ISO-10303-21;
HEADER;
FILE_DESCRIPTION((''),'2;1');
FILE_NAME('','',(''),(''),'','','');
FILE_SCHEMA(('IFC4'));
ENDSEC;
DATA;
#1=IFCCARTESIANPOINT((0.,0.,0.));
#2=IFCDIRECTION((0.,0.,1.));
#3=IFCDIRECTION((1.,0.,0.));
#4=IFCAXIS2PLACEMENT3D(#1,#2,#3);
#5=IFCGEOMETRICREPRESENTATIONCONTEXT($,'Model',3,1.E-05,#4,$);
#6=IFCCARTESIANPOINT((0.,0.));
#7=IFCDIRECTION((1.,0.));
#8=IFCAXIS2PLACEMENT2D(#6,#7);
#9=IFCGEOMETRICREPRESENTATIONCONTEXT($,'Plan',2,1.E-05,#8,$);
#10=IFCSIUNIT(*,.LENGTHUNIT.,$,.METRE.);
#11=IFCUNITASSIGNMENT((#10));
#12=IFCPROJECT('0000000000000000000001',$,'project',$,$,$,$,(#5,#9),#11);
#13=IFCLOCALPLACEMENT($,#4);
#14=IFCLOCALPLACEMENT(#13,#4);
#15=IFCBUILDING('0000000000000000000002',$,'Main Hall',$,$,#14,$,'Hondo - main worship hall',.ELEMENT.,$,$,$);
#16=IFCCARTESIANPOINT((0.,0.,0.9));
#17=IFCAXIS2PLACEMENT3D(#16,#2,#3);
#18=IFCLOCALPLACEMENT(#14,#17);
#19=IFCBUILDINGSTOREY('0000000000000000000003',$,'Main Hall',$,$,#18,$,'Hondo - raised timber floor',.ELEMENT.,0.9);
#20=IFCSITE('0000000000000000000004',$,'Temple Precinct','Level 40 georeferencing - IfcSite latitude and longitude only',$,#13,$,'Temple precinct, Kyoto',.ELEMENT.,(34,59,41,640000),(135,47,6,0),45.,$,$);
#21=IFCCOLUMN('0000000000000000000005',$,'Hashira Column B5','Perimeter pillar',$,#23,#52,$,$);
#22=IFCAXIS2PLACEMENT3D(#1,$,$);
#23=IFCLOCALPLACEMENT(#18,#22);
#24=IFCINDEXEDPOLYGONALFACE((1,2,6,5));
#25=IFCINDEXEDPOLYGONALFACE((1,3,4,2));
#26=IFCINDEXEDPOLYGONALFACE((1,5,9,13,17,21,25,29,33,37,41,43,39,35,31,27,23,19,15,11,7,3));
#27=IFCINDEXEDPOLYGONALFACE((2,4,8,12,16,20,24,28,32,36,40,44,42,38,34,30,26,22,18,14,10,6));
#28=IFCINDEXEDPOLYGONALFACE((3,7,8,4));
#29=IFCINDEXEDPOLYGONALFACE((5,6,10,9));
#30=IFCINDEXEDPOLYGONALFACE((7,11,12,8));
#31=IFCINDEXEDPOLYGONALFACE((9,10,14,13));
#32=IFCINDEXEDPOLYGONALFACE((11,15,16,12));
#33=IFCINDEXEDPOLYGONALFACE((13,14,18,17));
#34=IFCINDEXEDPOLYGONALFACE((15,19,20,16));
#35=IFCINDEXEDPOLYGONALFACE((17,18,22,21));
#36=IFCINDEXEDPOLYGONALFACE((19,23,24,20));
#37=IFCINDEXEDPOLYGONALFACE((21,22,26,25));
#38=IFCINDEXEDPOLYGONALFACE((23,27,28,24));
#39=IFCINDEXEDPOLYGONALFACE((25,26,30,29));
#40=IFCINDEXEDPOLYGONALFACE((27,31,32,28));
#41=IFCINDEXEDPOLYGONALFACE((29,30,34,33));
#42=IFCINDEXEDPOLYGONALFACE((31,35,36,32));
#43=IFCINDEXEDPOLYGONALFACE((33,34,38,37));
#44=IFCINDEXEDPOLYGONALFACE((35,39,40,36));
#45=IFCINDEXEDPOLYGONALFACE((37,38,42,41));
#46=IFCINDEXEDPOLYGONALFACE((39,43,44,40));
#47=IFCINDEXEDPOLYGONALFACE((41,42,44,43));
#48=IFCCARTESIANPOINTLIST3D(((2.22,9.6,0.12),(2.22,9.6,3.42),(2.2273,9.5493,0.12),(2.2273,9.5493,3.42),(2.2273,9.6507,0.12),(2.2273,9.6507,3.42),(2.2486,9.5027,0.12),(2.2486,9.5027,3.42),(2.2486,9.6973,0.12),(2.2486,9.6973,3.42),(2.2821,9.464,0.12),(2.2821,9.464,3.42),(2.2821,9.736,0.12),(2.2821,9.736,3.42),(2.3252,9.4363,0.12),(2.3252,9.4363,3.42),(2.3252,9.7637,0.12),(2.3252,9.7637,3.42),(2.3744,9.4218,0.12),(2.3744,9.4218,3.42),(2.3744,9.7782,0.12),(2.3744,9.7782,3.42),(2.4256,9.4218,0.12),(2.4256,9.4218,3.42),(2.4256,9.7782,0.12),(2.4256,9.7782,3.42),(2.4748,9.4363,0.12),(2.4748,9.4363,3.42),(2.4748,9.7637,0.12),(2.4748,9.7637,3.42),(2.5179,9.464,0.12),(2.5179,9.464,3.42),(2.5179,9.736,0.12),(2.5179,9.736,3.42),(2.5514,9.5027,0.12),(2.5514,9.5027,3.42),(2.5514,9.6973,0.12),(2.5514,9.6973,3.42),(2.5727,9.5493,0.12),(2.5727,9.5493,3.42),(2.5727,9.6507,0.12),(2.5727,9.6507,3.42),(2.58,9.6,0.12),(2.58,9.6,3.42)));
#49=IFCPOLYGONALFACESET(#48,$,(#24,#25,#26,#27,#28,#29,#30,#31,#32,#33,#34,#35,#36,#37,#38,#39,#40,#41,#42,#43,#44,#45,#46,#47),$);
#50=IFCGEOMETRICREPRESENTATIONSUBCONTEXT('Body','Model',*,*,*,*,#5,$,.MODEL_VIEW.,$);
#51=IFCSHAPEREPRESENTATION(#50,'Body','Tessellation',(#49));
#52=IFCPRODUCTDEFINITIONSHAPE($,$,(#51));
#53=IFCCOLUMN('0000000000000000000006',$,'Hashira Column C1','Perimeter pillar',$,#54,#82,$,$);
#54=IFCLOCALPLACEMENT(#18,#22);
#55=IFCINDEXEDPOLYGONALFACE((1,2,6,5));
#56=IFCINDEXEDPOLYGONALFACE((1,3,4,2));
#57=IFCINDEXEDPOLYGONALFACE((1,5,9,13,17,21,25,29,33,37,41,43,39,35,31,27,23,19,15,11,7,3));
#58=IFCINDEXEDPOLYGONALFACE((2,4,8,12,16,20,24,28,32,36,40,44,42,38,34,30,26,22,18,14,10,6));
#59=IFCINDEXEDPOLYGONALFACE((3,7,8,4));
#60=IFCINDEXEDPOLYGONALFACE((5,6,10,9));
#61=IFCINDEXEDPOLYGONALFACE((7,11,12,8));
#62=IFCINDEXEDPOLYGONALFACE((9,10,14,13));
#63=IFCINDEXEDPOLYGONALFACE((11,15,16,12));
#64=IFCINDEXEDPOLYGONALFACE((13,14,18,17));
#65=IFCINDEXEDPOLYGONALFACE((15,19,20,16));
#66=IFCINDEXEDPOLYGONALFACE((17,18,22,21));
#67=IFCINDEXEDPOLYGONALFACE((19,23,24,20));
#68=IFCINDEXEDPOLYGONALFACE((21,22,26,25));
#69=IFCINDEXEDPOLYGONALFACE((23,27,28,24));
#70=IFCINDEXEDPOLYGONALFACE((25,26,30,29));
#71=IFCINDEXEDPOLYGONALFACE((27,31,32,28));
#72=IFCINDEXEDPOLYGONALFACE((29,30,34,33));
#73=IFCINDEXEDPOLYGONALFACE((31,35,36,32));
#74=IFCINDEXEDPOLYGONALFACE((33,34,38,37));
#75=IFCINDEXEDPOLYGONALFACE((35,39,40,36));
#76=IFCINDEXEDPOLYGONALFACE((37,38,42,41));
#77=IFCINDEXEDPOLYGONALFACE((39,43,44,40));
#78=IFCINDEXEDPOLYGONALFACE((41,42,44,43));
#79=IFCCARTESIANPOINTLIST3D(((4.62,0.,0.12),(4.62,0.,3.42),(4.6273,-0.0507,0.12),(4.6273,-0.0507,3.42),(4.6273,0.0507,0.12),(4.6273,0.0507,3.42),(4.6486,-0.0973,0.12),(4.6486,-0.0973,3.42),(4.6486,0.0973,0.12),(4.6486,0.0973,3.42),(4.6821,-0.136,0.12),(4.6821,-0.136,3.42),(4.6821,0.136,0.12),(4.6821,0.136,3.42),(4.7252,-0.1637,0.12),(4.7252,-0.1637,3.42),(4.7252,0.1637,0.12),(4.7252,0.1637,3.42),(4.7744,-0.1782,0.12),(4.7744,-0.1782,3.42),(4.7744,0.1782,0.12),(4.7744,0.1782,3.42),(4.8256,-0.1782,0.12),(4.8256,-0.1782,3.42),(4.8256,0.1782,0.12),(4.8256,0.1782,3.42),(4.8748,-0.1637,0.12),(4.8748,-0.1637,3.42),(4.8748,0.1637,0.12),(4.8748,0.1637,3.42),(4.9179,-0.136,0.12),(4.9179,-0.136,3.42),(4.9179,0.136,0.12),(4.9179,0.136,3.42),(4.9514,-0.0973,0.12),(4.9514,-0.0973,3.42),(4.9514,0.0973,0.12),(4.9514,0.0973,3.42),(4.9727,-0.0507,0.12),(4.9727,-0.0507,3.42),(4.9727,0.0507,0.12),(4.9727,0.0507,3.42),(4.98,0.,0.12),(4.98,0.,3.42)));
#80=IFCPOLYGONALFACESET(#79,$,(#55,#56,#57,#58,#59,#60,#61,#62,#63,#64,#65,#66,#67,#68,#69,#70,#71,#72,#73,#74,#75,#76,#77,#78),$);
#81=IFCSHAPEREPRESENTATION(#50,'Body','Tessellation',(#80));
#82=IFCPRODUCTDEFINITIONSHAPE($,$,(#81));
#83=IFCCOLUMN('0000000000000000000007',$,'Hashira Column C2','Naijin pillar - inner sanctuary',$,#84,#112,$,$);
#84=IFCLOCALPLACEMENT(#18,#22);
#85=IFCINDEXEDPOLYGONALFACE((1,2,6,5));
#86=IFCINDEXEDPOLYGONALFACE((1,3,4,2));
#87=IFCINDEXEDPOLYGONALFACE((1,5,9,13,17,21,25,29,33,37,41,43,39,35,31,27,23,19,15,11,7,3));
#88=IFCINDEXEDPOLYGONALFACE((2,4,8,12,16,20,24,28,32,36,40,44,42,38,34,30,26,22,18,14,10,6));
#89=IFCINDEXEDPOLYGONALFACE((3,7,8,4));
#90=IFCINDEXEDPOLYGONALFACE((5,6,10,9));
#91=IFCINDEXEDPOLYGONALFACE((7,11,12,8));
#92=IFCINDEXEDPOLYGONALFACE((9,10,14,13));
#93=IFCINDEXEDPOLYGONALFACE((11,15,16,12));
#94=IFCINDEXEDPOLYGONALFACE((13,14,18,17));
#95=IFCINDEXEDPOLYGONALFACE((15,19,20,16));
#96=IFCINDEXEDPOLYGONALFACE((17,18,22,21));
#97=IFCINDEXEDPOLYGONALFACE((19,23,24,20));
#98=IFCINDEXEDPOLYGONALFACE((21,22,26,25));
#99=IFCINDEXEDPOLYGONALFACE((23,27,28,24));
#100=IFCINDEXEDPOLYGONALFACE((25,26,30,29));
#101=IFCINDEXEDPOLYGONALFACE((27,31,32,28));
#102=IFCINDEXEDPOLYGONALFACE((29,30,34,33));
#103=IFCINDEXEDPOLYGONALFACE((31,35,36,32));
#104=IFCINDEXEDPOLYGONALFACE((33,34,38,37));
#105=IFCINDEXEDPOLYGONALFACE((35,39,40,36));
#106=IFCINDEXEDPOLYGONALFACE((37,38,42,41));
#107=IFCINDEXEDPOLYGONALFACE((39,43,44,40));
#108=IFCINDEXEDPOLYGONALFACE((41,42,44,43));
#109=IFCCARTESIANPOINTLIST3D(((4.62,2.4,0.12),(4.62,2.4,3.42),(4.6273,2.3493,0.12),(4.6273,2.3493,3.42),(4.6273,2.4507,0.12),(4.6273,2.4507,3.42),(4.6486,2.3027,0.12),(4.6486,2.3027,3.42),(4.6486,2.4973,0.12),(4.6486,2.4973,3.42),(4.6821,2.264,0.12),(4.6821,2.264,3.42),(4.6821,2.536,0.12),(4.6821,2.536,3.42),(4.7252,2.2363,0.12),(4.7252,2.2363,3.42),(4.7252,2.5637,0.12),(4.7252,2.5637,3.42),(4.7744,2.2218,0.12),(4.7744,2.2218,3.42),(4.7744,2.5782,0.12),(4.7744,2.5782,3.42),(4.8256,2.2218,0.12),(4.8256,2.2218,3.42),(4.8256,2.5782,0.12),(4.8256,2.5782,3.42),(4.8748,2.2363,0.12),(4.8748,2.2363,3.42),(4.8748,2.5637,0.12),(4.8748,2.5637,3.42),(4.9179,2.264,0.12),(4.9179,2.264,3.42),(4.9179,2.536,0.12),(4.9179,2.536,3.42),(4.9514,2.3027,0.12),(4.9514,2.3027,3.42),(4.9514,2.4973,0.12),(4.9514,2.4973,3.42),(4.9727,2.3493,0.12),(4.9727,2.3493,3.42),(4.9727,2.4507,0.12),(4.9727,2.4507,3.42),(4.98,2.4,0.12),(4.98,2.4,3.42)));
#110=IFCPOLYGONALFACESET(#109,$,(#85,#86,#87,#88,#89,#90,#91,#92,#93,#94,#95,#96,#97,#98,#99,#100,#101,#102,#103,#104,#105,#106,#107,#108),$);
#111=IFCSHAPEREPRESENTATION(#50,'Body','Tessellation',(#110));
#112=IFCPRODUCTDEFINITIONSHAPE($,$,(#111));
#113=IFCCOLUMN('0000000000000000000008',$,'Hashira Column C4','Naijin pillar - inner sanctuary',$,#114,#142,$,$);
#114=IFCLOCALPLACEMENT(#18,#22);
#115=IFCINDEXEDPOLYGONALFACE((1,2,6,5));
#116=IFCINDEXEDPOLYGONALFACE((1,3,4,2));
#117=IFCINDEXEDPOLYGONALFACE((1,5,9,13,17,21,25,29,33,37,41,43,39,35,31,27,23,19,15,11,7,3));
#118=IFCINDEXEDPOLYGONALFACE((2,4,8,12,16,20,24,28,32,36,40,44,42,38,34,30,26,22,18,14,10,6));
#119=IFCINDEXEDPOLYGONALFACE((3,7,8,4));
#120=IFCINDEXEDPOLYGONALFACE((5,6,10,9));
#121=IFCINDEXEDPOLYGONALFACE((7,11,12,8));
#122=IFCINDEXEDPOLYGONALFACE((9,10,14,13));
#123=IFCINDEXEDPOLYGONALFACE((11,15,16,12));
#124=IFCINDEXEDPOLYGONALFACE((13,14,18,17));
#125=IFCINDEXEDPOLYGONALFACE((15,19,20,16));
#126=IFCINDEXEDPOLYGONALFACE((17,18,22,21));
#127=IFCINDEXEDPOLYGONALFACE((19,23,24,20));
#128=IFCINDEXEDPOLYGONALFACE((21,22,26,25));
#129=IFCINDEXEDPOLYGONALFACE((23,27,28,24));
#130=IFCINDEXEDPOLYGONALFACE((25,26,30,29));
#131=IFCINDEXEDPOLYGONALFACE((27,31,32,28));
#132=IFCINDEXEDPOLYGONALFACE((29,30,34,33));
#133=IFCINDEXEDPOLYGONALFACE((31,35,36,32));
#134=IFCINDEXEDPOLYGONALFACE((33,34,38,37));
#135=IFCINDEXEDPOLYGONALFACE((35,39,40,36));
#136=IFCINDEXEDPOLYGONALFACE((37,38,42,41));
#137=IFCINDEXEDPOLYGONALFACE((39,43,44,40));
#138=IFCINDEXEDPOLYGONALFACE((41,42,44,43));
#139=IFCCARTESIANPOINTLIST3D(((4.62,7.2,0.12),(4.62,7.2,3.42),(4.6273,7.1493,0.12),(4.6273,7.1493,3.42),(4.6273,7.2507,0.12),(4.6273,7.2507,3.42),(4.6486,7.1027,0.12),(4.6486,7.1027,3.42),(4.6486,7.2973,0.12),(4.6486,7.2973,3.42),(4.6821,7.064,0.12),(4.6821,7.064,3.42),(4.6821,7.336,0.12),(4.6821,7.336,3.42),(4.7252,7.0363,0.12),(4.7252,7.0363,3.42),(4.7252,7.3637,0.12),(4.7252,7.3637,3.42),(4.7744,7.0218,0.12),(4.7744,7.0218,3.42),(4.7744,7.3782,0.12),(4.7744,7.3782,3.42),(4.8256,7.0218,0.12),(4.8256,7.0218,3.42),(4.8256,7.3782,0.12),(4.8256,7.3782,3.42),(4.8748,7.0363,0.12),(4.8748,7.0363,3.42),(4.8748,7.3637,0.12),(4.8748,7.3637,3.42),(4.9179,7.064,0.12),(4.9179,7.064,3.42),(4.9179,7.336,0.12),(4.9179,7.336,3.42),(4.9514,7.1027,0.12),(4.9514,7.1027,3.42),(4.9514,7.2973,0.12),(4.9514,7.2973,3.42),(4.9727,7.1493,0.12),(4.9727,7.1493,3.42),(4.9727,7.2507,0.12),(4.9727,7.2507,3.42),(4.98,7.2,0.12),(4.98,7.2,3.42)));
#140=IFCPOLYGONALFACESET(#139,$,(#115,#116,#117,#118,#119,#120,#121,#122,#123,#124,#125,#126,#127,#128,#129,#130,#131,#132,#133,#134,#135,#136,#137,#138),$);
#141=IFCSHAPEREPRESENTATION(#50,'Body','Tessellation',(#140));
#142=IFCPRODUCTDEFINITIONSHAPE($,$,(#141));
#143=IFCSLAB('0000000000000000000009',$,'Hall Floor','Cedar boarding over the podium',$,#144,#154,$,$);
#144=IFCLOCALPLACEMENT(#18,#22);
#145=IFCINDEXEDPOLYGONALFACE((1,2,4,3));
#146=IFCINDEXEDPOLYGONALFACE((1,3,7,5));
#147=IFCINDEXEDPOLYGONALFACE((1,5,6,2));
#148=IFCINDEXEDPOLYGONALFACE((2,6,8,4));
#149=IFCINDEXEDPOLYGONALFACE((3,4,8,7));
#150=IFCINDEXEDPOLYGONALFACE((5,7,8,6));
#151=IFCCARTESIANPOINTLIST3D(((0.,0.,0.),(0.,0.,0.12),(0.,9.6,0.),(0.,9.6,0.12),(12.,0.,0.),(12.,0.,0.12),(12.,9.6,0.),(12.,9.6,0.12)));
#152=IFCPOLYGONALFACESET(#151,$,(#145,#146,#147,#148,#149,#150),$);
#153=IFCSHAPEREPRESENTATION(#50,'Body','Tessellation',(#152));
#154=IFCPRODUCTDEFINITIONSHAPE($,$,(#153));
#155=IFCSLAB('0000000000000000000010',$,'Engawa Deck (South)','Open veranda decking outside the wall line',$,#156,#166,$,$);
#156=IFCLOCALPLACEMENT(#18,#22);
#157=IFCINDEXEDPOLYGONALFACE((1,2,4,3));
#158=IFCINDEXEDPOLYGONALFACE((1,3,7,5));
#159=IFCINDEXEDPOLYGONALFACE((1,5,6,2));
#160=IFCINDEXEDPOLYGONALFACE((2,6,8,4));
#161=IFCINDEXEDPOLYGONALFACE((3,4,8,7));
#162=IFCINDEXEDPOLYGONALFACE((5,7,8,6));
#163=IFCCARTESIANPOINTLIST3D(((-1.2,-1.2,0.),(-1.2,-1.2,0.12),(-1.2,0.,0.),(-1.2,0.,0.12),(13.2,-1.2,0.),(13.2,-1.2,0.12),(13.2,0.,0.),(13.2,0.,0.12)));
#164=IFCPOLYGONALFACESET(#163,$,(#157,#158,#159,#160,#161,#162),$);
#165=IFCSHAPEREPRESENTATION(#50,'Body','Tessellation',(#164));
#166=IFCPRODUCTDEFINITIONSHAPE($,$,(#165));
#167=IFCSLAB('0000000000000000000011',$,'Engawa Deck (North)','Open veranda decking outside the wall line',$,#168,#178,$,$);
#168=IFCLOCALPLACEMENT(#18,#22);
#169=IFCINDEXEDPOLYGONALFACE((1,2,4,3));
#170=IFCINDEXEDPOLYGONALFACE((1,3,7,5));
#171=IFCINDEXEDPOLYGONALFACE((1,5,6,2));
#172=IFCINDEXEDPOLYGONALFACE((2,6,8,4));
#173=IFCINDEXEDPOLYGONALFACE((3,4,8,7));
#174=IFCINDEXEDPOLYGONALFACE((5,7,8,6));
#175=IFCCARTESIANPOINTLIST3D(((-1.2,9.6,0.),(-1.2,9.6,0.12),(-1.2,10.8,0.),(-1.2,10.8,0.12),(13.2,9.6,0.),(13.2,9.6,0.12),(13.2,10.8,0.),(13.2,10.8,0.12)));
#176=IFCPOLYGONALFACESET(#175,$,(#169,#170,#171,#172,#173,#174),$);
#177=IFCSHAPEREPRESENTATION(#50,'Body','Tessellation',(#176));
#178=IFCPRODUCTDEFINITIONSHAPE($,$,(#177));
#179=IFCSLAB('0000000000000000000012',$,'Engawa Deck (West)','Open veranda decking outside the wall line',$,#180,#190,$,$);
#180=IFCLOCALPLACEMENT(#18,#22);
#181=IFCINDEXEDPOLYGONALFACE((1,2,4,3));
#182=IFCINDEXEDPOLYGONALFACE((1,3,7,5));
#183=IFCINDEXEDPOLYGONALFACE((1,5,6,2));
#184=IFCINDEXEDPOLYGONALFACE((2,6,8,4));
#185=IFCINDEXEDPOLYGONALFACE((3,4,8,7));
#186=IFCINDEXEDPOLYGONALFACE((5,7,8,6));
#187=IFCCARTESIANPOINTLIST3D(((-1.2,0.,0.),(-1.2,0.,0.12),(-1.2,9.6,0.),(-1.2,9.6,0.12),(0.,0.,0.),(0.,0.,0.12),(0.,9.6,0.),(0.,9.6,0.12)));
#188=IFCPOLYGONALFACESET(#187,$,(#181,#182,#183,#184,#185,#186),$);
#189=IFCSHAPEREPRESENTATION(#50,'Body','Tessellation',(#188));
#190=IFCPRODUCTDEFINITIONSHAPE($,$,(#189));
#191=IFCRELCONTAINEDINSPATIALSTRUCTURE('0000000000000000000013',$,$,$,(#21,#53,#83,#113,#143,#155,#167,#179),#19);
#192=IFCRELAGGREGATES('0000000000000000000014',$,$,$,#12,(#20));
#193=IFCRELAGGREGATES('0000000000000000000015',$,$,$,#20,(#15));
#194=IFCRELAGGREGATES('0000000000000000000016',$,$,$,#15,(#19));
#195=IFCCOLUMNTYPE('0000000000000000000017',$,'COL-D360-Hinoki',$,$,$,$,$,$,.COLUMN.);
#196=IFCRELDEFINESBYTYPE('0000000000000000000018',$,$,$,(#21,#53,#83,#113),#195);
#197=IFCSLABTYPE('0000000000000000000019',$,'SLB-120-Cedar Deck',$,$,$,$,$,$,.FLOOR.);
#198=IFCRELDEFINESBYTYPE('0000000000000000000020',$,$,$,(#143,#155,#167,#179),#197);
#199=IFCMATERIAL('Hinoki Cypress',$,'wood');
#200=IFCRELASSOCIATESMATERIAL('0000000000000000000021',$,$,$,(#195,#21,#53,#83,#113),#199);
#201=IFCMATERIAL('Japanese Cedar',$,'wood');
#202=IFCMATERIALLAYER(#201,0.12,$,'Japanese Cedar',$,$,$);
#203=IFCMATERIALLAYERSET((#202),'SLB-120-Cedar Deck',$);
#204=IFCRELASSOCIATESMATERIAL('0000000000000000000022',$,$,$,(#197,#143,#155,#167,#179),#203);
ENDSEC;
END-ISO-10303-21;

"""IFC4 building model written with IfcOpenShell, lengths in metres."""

from ifc_helpers import new_model, si_unit, frame, origin_with_axes, origin_2d_with_axis, place, context, subcontext, project, spatial, line, indexed_curve, circle, outline, extrude, material, layer, layer_set, layer_usage, material_profile, profile_set, profile_usage, type_object, element, save


model = new_model("IFC4")

# Units and contexts
model_context = context("Model", 3, precision=1e-05, world=origin_with_axes())
plan_context = context("Plan", 2, precision=1e-05, world=origin_2d_with_axis())
body_context = subcontext(model_context, "Body", "Model", "MODEL_VIEW")
ifc_project = project(units=[si_unit("LENGTHUNIT", "METRE")], contexts=[model_context, plan_context])

# Site, building, storey
site_placement = place(None, origin_with_axes())
site = spatial("IfcSite", under=ifc_project, at=site_placement, Name="Temple Precinct", Description="Level 40 georeferencing - IfcSite latitude and longitude only", LongName="Temple precinct, Kyoto", CompositionType="ELEMENT", RefLatitude=(34, 59, 41, 640000), RefLongitude=(135, 47, 6, 0), RefElevation=45.0)
building_placement = place(site_placement, origin_with_axes())
building = spatial("IfcBuilding", under=site, at=building_placement, Name="Main Hall", LongName="Hondo - main worship hall", CompositionType="ELEMENT")
storey_placement = place(building_placement, frame((0.0, 0.0, 0.9), z_axis=(0.0, 0.0, 1.0), x_axis=(1.0, 0.0, 0.0)))
storey = spatial("IfcBuildingStorey", under=building, at=storey_placement, Name="Main Hall", LongName="Hondo - raised timber floor", CompositionType="ELEMENT", Elevation=0.9)

# Columns
ifc_material_1 = material(Name="Hinoki Cypress", Category="wood")
ifc_material_profile = material_profile(ifc_material_1, circle(Radius=0.18))
ifc_profile_set = profile_set([ifc_material_profile], Name="COL-D360-Hinoki")
column_type = type_object("IfcColumnType", Name="COL-D360-Hinoki", PredefinedType="COLUMN", material=ifc_profile_set)
ifc_profile_usage_1 = profile_usage(ifc_profile_set)
column_1_placement = place(storey_placement, frame((2.4, 9.6, 0.12), z_axis=(0.0, 0.0, 1.0), x_axis=(1.0, 0.0, 0.0)))
element("IfcColumn", 1, at=column_1_placement, inside=storey, type_object=column_type, material=ifc_profile_usage_1, Name="Hashira Column B5", Description="Perimeter pillar", context=body_context, shape_type="SweptSolid", body=[
    extrude(circle(Radius=0.18), origin_with_axes(), (0.0, 0.0, 1.0), 3.3),
])
ifc_profile_usage_2 = profile_usage(ifc_profile_set)
column_2_placement = place(storey_placement, frame((4.8, 0.0, 0.12), z_axis=(0.0, 0.0, 1.0), x_axis=(1.0, 0.0, 0.0)))
element("IfcColumn", 2, at=column_2_placement, inside=storey, type_object=column_type, material=ifc_profile_usage_2, Name="Hashira Column C1", Description="Perimeter pillar", context=body_context, shape_type="SweptSolid", body=[
    extrude(circle(Radius=0.18), origin_with_axes(), (0.0, 0.0, 1.0), 3.3),
])
ifc_profile_usage_3 = profile_usage(ifc_profile_set)
column_3_placement = place(storey_placement, frame((4.8, 2.4, 0.12), z_axis=(0.0, 0.0, 1.0), x_axis=(1.0, 0.0, 0.0)))
element("IfcColumn", 3, at=column_3_placement, inside=storey, type_object=column_type, material=ifc_profile_usage_3, Name="Hashira Column C2", Description="Naijin pillar - inner sanctuary", context=body_context, shape_type="SweptSolid", body=[
    extrude(circle(Radius=0.18), origin_with_axes(), (0.0, 0.0, 1.0), 3.3),
])
ifc_profile_usage_4 = profile_usage(ifc_profile_set)
column_4_placement = place(storey_placement, frame((4.8, 7.2, 0.12), z_axis=(0.0, 0.0, 1.0), x_axis=(1.0, 0.0, 0.0)))
element("IfcColumn", 4, at=column_4_placement, inside=storey, type_object=column_type, material=ifc_profile_usage_4, Name="Hashira Column C4", Description="Naijin pillar - inner sanctuary", context=body_context, shape_type="SweptSolid", body=[
    extrude(circle(Radius=0.18), origin_with_axes(), (0.0, 0.0, 1.0), 3.3),
])

# Slabs
ifc_material_2 = material(Name="Japanese Cedar", Category="wood")
ifc_layer_1 = layer(ifc_material_2, 0.12, Name="Japanese Cedar")
ifc_layer_set_1 = layer_set([ifc_layer_1], Name="SLB-120-Cedar Deck")
ifc_layer_usage_1 = layer_usage(ifc_layer_set_1, "AXIS3", "POSITIVE", 0.0)
slab_type = type_object("IfcSlabType", Name="SLB-120-Cedar Deck", PredefinedType="FLOOR", material=ifc_layer_set_1)
slab_1_placement = place(storey_placement, origin_with_axes())
element("IfcSlab", 5, at=slab_1_placement, inside=storey, type_object=slab_type, material=ifc_layer_usage_1, Name="Hall Floor", Description="Cedar boarding over the podium", context=body_context, shape_type="SweptSolid", body=[
    extrude(outline(indexed_curve([(0.0, 0.0), (12.0, 0.0), (12.0, 9.6), (0.0, 9.6)], segments=[line(1, 2, 3, 4, 1)])), origin_with_axes(), (0.0, 0.0, 1.0), 0.12),
])
ifc_layer_usage_2 = layer_usage(ifc_layer_set_1, "AXIS3", "POSITIVE", 0.0)
slab_2_placement = place(storey_placement, frame((-1.2, -1.2, 0.0), z_axis=(0.0, 0.0, 1.0), x_axis=(1.0, 0.0, 0.0)))
element("IfcSlab", 6, at=slab_2_placement, inside=storey, type_object=slab_type, material=ifc_layer_usage_2, Name="Engawa Deck (South)", Description="Open veranda decking outside the wall line", context=body_context, shape_type="SweptSolid", body=[
    extrude(outline(indexed_curve([(0.0, 0.0), (14.4, 0.0), (14.4, 1.2), (0.0, 1.2)], segments=[line(1, 2, 3, 4, 1)])), origin_with_axes(), (0.0, 0.0, 1.0), 0.12),
])
ifc_layer_usage_3 = layer_usage(ifc_layer_set_1, "AXIS3", "POSITIVE", 0.0)
slab_3_placement = place(storey_placement, frame((-1.2, 9.6, 0.0), z_axis=(0.0, 0.0, 1.0), x_axis=(1.0, 0.0, 0.0)))
element("IfcSlab", 7, at=slab_3_placement, inside=storey, type_object=slab_type, material=ifc_layer_usage_3, Name="Engawa Deck (North)", Description="Open veranda decking outside the wall line", context=body_context, shape_type="SweptSolid", body=[
    extrude(outline(indexed_curve([(0.0, 0.0), (14.4, 0.0), (14.4, 1.2), (0.0, 1.2)], segments=[line(1, 2, 3, 4, 1)])), origin_with_axes(), (0.0, 0.0, 1.0), 0.12),
])
ifc_layer_usage_4 = layer_usage(ifc_layer_set_1, "AXIS3", "POSITIVE", 0.0)
slab_4_placement = place(storey_placement, frame((-1.2, 0.0, 0.0), z_axis=(0.0, 0.0, 1.0), x_axis=(1.0, 0.0, 0.0)))
element("IfcSlab", 8, at=slab_4_placement, inside=storey, type_object=slab_type, material=ifc_layer_usage_4, Name="Engawa Deck (West)", Description="Open veranda decking outside the wall line", context=body_context, shape_type="SweptSolid", body=[
    extrude(outline(indexed_curve([(0.0, 0.0), (1.2, 0.0), (1.2, 9.6), (0.0, 9.6)], segments=[line(1, 2, 3, 4, 1)])), origin_with_axes(), (0.0, 0.0, 1.0), 0.12),
])

save(model, "model.ifc")
